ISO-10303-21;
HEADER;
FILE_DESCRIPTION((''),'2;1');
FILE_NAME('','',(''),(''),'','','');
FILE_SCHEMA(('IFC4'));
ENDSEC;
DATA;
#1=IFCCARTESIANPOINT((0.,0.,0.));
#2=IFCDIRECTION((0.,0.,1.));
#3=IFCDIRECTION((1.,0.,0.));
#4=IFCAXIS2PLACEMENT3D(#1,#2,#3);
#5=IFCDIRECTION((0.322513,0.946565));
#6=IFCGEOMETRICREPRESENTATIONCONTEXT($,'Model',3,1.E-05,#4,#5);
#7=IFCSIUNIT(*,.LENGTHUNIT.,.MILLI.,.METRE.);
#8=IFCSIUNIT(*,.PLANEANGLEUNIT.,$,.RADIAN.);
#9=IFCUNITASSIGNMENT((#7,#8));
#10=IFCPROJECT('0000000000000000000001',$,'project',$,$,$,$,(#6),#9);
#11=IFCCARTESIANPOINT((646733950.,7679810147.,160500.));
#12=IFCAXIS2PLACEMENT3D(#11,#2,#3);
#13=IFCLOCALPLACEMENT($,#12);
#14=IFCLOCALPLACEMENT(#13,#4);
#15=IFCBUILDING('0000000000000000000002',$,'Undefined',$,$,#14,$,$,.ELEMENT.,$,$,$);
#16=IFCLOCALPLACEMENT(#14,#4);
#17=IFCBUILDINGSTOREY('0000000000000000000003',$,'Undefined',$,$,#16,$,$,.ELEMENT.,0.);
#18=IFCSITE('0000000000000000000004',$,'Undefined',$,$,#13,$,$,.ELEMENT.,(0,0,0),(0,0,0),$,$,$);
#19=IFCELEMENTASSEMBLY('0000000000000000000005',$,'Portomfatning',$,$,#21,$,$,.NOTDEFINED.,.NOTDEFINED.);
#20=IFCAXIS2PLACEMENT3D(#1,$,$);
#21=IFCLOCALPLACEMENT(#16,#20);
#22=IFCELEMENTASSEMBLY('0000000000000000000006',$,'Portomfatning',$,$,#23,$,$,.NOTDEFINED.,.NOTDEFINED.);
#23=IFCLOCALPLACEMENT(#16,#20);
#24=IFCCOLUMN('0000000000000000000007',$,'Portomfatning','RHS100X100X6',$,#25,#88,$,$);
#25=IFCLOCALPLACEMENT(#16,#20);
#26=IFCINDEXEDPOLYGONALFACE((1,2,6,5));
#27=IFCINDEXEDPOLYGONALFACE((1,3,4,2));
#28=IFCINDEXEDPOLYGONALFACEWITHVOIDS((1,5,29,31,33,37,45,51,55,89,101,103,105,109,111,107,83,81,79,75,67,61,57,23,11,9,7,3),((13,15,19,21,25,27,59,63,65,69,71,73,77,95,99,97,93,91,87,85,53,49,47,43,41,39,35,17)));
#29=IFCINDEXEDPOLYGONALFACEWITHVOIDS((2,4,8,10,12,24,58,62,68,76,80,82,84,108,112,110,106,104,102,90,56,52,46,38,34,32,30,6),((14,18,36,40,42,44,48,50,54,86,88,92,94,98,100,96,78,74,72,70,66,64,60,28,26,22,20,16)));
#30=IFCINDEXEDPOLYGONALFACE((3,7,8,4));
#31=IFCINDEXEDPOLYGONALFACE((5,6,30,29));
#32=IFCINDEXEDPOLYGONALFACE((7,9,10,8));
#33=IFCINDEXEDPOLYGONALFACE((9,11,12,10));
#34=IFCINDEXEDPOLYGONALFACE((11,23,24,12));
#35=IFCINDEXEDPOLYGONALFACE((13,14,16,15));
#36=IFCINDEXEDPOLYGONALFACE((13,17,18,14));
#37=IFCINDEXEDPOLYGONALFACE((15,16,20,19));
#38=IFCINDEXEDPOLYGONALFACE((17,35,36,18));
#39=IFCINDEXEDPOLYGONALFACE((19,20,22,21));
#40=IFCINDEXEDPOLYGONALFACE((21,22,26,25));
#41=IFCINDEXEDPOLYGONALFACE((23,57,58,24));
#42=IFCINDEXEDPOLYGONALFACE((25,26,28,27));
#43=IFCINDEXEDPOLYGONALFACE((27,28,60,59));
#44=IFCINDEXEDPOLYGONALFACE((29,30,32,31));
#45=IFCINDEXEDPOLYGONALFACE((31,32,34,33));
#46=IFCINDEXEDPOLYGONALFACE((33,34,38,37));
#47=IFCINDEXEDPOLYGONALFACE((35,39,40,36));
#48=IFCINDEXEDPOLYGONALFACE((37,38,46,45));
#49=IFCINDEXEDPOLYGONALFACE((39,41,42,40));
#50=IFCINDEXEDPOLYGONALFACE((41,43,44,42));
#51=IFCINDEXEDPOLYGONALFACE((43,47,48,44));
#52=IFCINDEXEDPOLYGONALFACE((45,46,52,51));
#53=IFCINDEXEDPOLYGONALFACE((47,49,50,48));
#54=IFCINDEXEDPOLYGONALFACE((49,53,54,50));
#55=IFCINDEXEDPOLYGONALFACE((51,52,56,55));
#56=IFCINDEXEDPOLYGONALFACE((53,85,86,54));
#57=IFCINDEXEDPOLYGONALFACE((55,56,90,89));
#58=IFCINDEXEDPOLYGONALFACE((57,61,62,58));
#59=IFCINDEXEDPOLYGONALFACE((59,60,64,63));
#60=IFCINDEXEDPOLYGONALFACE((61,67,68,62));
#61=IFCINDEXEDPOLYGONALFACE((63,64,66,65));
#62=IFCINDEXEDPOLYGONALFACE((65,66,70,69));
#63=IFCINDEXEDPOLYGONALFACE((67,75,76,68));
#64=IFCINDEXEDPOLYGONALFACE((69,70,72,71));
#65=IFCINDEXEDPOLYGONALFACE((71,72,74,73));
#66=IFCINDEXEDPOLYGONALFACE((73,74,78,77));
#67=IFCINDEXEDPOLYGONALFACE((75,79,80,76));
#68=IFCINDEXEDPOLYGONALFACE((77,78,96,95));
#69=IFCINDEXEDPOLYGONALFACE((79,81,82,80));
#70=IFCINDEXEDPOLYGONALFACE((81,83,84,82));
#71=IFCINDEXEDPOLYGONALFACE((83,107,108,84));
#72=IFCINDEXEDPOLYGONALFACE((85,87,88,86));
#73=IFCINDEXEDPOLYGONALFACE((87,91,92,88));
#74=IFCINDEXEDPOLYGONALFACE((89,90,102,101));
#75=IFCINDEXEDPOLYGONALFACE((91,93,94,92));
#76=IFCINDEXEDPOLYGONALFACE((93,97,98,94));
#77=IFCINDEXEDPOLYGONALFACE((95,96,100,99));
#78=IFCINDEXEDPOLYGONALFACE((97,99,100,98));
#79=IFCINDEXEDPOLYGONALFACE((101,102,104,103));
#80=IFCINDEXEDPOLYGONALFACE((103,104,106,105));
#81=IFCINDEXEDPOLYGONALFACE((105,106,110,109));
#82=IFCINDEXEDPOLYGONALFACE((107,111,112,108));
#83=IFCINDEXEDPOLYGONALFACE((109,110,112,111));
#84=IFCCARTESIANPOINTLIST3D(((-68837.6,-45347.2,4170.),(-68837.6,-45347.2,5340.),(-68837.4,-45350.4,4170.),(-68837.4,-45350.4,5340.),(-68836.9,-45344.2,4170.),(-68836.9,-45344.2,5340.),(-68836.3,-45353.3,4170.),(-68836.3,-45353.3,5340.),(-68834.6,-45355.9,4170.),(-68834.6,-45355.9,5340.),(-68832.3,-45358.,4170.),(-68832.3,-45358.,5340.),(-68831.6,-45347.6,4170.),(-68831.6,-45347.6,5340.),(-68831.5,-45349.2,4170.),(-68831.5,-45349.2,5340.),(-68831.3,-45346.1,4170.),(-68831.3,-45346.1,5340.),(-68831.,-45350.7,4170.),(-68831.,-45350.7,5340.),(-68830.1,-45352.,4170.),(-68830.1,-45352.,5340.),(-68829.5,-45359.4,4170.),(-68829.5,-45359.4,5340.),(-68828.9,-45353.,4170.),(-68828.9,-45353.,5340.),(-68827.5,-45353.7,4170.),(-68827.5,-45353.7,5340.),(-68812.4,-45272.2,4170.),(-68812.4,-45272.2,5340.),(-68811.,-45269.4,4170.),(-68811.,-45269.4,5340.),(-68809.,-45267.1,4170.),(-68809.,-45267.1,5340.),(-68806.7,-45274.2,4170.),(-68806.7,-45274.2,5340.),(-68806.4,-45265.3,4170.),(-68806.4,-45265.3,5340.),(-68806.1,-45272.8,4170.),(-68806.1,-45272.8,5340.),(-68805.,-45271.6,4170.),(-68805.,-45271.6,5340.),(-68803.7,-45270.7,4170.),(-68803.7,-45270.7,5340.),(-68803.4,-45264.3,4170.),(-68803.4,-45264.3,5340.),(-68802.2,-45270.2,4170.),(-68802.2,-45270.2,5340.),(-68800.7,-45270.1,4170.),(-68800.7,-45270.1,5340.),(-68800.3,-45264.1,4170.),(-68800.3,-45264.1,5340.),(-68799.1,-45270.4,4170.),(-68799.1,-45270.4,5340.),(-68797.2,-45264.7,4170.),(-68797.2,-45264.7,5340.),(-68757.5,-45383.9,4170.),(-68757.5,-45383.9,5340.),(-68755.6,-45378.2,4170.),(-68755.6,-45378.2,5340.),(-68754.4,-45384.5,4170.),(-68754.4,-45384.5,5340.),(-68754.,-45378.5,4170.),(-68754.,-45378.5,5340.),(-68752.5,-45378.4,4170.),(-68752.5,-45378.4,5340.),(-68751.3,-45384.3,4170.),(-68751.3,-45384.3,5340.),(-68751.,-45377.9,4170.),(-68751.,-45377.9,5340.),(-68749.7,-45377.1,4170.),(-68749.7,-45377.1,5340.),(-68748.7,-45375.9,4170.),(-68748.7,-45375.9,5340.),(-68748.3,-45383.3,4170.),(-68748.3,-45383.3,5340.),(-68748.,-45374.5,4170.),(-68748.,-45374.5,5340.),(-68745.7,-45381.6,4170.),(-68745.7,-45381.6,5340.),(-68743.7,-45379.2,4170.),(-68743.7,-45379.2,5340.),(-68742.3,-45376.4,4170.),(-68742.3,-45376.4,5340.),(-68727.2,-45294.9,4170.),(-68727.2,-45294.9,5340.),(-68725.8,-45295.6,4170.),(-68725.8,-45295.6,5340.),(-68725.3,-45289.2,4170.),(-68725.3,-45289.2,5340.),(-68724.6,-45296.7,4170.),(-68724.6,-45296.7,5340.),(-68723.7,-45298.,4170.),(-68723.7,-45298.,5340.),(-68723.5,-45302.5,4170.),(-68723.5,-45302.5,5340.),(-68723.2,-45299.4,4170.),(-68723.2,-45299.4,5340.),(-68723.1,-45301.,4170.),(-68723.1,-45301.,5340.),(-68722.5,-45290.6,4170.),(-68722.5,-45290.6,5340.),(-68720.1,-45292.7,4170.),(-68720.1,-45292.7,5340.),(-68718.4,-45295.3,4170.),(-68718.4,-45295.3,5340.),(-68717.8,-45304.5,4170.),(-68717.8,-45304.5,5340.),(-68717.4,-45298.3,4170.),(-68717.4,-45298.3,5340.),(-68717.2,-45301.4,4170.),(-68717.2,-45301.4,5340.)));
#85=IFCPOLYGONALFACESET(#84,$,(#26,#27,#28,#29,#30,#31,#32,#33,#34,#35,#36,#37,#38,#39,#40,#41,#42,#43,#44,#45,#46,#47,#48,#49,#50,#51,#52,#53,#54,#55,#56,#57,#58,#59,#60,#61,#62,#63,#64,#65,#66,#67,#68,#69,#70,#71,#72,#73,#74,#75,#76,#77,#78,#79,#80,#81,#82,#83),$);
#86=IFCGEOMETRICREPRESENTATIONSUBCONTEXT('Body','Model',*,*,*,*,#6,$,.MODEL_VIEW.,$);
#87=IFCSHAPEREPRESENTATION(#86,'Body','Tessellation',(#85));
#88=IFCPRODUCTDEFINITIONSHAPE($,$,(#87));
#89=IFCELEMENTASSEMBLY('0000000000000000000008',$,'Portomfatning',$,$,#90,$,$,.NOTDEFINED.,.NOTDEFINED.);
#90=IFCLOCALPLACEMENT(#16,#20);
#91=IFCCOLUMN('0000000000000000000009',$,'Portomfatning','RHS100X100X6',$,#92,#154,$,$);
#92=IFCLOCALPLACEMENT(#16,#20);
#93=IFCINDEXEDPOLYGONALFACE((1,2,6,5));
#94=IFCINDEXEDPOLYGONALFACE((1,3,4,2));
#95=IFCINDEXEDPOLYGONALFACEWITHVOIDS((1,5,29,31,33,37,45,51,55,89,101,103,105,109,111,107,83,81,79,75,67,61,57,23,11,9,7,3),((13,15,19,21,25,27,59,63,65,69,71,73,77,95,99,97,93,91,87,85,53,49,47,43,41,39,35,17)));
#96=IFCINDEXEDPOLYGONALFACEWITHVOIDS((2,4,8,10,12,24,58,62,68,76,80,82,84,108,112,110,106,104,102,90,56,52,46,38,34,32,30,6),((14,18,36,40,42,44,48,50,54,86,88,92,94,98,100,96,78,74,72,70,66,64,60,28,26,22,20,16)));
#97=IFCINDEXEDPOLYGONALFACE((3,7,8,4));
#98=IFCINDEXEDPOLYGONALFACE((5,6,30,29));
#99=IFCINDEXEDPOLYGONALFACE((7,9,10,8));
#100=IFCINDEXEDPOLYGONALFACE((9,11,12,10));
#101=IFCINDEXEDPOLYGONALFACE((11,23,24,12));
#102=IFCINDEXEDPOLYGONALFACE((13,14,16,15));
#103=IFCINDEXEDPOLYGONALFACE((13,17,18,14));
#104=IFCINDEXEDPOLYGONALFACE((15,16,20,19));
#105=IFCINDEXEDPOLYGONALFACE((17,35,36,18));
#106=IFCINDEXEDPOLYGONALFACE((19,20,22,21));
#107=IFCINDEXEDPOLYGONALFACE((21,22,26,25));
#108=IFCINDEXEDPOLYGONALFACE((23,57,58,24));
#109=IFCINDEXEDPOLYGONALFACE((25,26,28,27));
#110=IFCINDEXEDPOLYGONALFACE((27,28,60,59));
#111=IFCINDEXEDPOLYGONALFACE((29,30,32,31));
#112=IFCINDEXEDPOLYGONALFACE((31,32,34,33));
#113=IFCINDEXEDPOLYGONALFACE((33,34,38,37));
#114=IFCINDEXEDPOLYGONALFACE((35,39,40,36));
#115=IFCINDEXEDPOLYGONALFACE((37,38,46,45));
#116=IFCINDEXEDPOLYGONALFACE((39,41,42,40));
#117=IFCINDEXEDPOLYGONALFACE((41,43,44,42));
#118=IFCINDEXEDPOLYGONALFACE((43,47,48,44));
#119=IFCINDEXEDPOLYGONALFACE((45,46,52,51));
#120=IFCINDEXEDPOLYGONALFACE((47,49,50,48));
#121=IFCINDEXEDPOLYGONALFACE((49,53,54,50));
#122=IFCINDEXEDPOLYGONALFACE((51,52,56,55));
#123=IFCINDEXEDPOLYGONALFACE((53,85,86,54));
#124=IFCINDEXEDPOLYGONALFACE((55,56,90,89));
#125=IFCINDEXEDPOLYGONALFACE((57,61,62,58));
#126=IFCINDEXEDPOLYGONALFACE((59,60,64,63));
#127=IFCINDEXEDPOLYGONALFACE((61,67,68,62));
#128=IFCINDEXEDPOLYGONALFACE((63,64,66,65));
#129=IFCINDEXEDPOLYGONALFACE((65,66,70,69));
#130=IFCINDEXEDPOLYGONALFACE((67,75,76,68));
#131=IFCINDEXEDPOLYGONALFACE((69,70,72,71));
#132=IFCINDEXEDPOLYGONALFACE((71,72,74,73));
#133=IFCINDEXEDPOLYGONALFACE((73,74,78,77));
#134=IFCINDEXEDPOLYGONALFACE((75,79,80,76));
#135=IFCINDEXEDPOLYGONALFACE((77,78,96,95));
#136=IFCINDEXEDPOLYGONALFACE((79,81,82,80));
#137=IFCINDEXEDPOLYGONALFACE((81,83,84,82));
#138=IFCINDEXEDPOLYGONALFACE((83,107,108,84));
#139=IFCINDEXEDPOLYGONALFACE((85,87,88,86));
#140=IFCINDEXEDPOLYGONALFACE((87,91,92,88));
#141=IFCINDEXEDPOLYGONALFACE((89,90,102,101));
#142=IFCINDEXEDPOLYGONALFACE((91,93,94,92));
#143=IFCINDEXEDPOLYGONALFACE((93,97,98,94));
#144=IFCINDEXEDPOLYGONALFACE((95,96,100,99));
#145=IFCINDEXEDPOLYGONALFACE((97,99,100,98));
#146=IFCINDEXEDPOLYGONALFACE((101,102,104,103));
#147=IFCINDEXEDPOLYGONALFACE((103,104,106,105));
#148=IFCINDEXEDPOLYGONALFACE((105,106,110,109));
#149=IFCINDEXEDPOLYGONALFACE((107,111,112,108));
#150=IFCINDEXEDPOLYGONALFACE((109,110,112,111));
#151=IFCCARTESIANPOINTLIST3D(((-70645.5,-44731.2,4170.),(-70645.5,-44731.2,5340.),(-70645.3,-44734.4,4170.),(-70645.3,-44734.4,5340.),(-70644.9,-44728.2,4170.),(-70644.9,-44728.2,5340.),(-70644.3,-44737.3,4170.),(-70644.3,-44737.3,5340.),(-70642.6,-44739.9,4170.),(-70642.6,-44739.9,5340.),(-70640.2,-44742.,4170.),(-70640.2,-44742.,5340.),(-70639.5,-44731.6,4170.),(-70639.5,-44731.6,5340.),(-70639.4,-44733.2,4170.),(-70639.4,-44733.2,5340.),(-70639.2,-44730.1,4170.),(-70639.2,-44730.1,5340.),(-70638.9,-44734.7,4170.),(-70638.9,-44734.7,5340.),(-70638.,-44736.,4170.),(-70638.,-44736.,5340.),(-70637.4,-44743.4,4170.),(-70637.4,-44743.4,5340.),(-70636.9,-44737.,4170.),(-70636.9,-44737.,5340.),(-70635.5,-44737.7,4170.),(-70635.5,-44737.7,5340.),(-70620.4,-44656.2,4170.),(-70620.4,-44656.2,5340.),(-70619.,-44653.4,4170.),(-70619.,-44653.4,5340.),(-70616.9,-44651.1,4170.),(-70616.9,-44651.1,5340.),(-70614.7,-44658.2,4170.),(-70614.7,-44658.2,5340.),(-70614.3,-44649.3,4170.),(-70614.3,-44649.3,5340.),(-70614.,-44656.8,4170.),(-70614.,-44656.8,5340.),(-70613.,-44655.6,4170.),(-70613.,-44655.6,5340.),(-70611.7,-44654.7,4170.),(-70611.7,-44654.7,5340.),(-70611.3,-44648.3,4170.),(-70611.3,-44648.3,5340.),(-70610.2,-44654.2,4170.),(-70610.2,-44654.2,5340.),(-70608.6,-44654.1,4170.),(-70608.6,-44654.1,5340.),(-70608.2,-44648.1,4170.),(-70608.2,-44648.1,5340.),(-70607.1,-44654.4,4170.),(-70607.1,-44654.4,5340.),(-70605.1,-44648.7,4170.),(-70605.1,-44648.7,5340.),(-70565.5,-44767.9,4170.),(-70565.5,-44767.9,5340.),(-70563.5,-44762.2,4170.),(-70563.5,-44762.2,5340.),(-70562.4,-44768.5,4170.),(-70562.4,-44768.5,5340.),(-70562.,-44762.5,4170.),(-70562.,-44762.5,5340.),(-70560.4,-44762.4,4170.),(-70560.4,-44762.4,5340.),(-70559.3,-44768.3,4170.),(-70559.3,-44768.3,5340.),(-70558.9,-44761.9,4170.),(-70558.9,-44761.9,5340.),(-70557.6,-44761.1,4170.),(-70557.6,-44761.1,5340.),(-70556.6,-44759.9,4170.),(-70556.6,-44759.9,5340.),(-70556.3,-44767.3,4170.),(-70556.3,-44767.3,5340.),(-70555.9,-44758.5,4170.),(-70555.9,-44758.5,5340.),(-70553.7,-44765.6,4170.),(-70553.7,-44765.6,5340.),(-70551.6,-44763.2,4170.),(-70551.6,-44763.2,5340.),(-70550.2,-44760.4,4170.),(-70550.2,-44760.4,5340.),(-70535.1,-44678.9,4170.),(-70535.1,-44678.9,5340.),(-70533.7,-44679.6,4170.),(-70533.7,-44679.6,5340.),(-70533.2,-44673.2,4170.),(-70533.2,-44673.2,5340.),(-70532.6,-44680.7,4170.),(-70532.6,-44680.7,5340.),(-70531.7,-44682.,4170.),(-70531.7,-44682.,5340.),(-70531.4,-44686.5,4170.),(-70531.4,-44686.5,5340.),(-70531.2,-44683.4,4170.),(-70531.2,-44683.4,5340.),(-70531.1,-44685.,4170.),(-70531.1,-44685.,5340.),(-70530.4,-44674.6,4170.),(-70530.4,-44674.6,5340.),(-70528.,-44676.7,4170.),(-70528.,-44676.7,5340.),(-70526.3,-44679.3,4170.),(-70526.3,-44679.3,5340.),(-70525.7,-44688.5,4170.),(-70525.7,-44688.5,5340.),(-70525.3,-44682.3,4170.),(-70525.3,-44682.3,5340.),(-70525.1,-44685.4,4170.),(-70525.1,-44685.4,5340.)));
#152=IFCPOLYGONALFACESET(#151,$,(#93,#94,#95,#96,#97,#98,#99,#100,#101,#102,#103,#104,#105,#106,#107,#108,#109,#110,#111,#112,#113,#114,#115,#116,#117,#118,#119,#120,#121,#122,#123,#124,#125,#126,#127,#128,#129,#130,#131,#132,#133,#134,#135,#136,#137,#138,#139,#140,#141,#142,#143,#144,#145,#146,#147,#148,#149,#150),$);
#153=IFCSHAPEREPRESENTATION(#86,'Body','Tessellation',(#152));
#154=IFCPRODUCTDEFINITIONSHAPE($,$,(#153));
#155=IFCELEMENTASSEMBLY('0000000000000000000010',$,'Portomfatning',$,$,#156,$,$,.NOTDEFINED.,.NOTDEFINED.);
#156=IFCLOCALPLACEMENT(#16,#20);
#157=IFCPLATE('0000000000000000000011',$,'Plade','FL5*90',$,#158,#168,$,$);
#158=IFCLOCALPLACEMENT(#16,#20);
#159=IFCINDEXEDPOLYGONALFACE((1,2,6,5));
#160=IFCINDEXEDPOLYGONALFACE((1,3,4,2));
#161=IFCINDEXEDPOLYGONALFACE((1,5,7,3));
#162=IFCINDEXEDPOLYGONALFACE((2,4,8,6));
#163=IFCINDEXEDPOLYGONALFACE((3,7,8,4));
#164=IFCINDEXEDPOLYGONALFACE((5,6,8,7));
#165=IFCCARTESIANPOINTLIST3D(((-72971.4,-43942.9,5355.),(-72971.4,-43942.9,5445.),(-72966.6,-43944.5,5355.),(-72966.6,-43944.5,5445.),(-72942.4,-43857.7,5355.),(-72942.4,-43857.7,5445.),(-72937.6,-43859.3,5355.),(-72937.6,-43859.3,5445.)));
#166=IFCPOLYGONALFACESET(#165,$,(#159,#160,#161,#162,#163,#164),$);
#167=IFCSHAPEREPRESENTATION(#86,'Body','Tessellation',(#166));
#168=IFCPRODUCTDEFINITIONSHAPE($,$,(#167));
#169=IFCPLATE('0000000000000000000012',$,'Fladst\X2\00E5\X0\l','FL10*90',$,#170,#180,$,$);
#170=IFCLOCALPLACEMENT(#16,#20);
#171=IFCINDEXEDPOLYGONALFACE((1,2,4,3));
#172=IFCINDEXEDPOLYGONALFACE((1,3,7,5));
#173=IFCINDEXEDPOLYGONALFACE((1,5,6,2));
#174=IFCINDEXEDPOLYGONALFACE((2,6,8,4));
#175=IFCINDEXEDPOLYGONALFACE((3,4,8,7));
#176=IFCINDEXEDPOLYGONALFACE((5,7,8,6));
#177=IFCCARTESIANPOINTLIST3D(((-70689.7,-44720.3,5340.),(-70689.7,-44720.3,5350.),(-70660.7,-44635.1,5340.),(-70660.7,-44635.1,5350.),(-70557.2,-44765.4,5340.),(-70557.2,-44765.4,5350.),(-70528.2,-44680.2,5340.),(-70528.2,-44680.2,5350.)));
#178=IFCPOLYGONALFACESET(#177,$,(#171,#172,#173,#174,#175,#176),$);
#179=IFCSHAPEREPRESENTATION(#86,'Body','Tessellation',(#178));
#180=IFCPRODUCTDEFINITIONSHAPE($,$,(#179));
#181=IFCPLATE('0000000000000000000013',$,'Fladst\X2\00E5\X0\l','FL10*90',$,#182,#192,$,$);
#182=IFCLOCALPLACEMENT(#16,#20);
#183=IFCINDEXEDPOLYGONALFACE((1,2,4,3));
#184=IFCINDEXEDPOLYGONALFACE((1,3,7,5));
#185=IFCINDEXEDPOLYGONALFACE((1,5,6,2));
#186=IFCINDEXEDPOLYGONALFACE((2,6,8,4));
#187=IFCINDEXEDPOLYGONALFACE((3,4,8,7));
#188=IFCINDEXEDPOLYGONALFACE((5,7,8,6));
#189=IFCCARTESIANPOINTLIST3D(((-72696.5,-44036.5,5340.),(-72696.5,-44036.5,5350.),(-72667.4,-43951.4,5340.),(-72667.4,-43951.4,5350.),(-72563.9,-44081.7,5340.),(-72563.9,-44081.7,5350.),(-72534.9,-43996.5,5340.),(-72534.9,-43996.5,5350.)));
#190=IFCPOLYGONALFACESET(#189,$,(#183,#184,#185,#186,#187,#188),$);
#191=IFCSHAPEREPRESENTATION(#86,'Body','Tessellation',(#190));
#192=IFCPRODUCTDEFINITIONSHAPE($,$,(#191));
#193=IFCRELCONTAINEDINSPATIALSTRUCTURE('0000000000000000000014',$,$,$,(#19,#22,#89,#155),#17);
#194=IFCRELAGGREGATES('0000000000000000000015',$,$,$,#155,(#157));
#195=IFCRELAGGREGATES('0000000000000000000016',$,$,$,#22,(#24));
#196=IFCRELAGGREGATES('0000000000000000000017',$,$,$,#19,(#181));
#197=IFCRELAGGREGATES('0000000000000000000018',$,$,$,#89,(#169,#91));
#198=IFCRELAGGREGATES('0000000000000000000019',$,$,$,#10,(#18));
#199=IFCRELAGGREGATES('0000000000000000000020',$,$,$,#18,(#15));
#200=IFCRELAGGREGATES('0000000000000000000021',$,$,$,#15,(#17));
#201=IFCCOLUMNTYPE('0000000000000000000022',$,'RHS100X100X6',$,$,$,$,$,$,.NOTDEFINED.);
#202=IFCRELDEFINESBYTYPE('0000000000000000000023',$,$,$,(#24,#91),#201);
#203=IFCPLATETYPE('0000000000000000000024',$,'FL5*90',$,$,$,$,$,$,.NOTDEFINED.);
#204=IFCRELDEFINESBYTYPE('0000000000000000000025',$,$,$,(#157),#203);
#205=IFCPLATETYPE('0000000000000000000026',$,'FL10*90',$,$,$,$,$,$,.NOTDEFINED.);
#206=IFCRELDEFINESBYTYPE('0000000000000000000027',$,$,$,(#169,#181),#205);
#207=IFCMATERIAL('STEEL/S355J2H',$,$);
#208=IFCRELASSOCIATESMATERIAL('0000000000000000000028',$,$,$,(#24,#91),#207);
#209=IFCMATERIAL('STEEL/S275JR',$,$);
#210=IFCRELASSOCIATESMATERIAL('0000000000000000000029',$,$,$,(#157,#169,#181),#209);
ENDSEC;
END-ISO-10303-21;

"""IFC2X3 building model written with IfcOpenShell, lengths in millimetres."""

from ifc_helpers import new_model, si_unit, direction, frame, origin_with_axes, origin_2d_with_axis, place, context, subcontext, project, spatial, polyline, hollow_rectangle, outline, extrude, clip, halfspace, material, type_object, element, aggregate, save


model = new_model("IFC2X3")

# Units and contexts
model_context = context("Model", 3, precision=1e-05, world=origin_with_axes(), true_north=direction((0.322513, 0.946565)))
body_context = subcontext(model_context, "Body", "Model", "MODEL_VIEW")
ifc_project = project(units=[si_unit("LENGTHUNIT", "METRE", prefix="MILLI"), si_unit("PLANEANGLEUNIT", "RADIAN")], contexts=[model_context])

# Site, building, storey
site_placement = place(None, frame((646733950.0, 7679810147.0, 160500.0), z_axis=(0.0, 0.0, 1.0), x_axis=(1.0, 0.0, 0.0)))
site = spatial("IfcSite", under=ifc_project, at=site_placement, Name="Undefined", CompositionType="ELEMENT", RefLatitude=(0, 0, 0), RefLongitude=(0, 0, 0))
building_placement = place(site_placement, origin_with_axes())
building = spatial("IfcBuilding", under=site, at=building_placement, Name="Undefined", CompositionType="ELEMENT")
storey_placement = place(building_placement, origin_with_axes())
storey = spatial("IfcBuildingStorey", under=building, at=storey_placement, Name="Undefined", CompositionType="ELEMENT", Elevation=0.0)

# Element assemblies, columns
ifc_material_1 = material(Name="STEEL/S355J2H")
column_type = type_object("IfcColumnType", Name="RHS100X100X6", PredefinedType="NOTDEFINED")
assembly_1_placement = place(storey_placement, origin_with_axes())
assembly_1 = element("IfcElementAssembly", 1, at=assembly_1_placement, inside=storey, Name="Portomfatning", AssemblyPlace="NOTDEFINED", PredefinedType="NOTDEFINED")
assembly_2_placement = place(storey_placement, origin_with_axes())
assembly_2 = element("IfcElementAssembly", 2, at=assembly_2_placement, inside=storey, Name="Portomfatning", AssemblyPlace="NOTDEFINED", PredefinedType="NOTDEFINED")
column_1_placement = place(assembly_2_placement, frame((-68777.4, -45324.3, 4160.0), z_axis=(0.0, 0.0, 1.0), x_axis=(-0.322513, -0.946565, 0.0)))
column_1 = element("IfcColumn", 3, at=column_1_placement, type_object=column_type, material=ifc_material_1, Name="Portomfatning", Description="RHS100X100X6", context=body_context, shape_type="Clipping", body=[
    clip(clip(extrude(hollow_rectangle(XDim=100.0, YDim=100.0, WallThickness=6.0, InnerFilletRadius=6.0, OuterFilletRadius=12.0, at=origin_2d_with_axis()), frame((0.0, 0.0, 1190.0), z_axis=(0.0, 0.0, -1.0), x_axis=(0.0, 1.0, 0.0)), (0.0, 0.0, 1.0), 1190.0), halfspace(frame((0.0, -50.0, 1180.0), z_axis=(0.0, 0.0, -1.0), x_axis=(1.0, 0.0, 0.0)), True)), halfspace(frame((0.0, -50.0, 10.0), z_axis=(0.0, 0.0, 1.0), x_axis=(-1.0, 0.0, 0.0)), True)),
])
assembly_3_placement = place(storey_placement, origin_with_axes())
assembly_3 = element("IfcElementAssembly", 4, at=assembly_3_placement, inside=storey, Name="Portomfatning", AssemblyPlace="NOTDEFINED", PredefinedType="NOTDEFINED")
column_2_placement = place(assembly_3_placement, frame((-70585.3, -44708.3, 4160.0), z_axis=(0.0, 0.0, 1.0), x_axis=(-0.322513, -0.946565, 0.0)))
column_2 = element("IfcColumn", 5, at=column_2_placement, type_object=column_type, material=ifc_material_1, Name="Portomfatning", Description="RHS100X100X6", context=body_context, shape_type="Clipping", body=[
    clip(clip(extrude(hollow_rectangle(XDim=100.0, YDim=100.0, WallThickness=6.0, InnerFilletRadius=6.0, OuterFilletRadius=12.0, at=origin_2d_with_axis()), frame((0.0, 0.0, 1190.0), z_axis=(0.0, 0.0, -1.0), x_axis=(0.0, 1.0, 0.0)), (0.0, 0.0, 1.0), 1190.0), halfspace(frame((0.0, 50.0, 1180.0), z_axis=(0.0, 0.0, -1.0), x_axis=(-1.0, 0.0, 0.0)), True)), halfspace(frame((0.0, 50.0, 10.0), z_axis=(0.0, 0.0, 1.0), x_axis=(1.0, 0.0, 0.0)), True)),
])

# Element assembly, plate
assembly_4_placement = place(storey_placement, origin_with_axes())
assembly_4 = element("IfcElementAssembly", 6, at=assembly_4_placement, inside=storey, Name="Portomfatning", AssemblyPlace="NOTDEFINED", PredefinedType="NOTDEFINED")
ifc_material_2 = material(Name="STEEL/S275JR")
plate_type_1 = type_object("IfcPlateType", Name="FL5*90", PredefinedType="NOTDEFINED")
plate_1_placement = place(assembly_4_placement, frame((-72940.0, -43858.5, 5445.0), z_axis=(-0.946625, 0.322338, 0.0), x_axis=(0.0, 0.0, -1.0)))
plate_1 = element("IfcPlate", 7, at=plate_1_placement, type_object=plate_type_1, material=ifc_material_2, Name="Plade", Description="FL5*90", context=body_context, shape_type="SweptSolid", body=[
    extrude(outline(polyline([(0.0, 0.0), (90.0, 0.0), (90.0, 90.0), (0.0, 90.0), (0.0, 0.0)])), frame((0.0, 0.0, -2.5), z_axis=(0.0, 0.0, 1.0), x_axis=(1.0, 0.0, 0.0)), (0.0, 0.0, 1.0), 5.0),
])
aggregate(assembly_4, [plate_1])

# Plates
plate_type_2 = type_object("IfcPlateType", Name="FL10*90", PredefinedType="NOTDEFINED")
plate_2_placement = place(assembly_3_placement, frame((-70542.7, -44722.8, 5345.0), z_axis=(0.0, 0.0, -1.0), x_axis=(-0.946565, 0.322513, 0.0)))
plate_2 = element("IfcPlate", 8, at=plate_2_placement, type_object=plate_type_2, material=ifc_material_2, Name="Fladstål", Description="FL10*90", context=body_context, shape_type="SweptSolid", body=[
    extrude(outline(polyline([(0.0, -45.0), (0.0, 45.0), (140.0, 45.0), (140.0, -45.0), (0.0, -45.0)])), frame((0.0, 0.0, -5.0), z_axis=(0.0, 0.0, 1.0), x_axis=(1.0, 0.0, 0.0)), (0.0, 0.0, 1.0), 10.0),
])
plate_3_placement = place(assembly_1_placement, frame((-72549.4, -44039.1, 5345.0), z_axis=(0.0, 0.0, -1.0), x_axis=(-0.946565, 0.322513, 0.0)))
plate_3 = element("IfcPlate", 9, at=plate_3_placement, type_object=plate_type_2, material=ifc_material_2, Name="Fladstål", Description="FL10*90", context=body_context, shape_type="SweptSolid", body=[
    extrude(outline(polyline([(0.0, -45.0), (0.0, 45.0), (140.0, 45.0), (140.0, -45.0), (0.0, -45.0)])), frame((0.0, 0.0, -5.0), z_axis=(0.0, 0.0, 1.0), x_axis=(1.0, 0.0, 0.0)), (0.0, 0.0, 1.0), 10.0),
])

aggregate(assembly_2, [column_1])
aggregate(assembly_1, [plate_3])
aggregate(assembly_3, [plate_2, column_2])

save(model, "model.ifc")
